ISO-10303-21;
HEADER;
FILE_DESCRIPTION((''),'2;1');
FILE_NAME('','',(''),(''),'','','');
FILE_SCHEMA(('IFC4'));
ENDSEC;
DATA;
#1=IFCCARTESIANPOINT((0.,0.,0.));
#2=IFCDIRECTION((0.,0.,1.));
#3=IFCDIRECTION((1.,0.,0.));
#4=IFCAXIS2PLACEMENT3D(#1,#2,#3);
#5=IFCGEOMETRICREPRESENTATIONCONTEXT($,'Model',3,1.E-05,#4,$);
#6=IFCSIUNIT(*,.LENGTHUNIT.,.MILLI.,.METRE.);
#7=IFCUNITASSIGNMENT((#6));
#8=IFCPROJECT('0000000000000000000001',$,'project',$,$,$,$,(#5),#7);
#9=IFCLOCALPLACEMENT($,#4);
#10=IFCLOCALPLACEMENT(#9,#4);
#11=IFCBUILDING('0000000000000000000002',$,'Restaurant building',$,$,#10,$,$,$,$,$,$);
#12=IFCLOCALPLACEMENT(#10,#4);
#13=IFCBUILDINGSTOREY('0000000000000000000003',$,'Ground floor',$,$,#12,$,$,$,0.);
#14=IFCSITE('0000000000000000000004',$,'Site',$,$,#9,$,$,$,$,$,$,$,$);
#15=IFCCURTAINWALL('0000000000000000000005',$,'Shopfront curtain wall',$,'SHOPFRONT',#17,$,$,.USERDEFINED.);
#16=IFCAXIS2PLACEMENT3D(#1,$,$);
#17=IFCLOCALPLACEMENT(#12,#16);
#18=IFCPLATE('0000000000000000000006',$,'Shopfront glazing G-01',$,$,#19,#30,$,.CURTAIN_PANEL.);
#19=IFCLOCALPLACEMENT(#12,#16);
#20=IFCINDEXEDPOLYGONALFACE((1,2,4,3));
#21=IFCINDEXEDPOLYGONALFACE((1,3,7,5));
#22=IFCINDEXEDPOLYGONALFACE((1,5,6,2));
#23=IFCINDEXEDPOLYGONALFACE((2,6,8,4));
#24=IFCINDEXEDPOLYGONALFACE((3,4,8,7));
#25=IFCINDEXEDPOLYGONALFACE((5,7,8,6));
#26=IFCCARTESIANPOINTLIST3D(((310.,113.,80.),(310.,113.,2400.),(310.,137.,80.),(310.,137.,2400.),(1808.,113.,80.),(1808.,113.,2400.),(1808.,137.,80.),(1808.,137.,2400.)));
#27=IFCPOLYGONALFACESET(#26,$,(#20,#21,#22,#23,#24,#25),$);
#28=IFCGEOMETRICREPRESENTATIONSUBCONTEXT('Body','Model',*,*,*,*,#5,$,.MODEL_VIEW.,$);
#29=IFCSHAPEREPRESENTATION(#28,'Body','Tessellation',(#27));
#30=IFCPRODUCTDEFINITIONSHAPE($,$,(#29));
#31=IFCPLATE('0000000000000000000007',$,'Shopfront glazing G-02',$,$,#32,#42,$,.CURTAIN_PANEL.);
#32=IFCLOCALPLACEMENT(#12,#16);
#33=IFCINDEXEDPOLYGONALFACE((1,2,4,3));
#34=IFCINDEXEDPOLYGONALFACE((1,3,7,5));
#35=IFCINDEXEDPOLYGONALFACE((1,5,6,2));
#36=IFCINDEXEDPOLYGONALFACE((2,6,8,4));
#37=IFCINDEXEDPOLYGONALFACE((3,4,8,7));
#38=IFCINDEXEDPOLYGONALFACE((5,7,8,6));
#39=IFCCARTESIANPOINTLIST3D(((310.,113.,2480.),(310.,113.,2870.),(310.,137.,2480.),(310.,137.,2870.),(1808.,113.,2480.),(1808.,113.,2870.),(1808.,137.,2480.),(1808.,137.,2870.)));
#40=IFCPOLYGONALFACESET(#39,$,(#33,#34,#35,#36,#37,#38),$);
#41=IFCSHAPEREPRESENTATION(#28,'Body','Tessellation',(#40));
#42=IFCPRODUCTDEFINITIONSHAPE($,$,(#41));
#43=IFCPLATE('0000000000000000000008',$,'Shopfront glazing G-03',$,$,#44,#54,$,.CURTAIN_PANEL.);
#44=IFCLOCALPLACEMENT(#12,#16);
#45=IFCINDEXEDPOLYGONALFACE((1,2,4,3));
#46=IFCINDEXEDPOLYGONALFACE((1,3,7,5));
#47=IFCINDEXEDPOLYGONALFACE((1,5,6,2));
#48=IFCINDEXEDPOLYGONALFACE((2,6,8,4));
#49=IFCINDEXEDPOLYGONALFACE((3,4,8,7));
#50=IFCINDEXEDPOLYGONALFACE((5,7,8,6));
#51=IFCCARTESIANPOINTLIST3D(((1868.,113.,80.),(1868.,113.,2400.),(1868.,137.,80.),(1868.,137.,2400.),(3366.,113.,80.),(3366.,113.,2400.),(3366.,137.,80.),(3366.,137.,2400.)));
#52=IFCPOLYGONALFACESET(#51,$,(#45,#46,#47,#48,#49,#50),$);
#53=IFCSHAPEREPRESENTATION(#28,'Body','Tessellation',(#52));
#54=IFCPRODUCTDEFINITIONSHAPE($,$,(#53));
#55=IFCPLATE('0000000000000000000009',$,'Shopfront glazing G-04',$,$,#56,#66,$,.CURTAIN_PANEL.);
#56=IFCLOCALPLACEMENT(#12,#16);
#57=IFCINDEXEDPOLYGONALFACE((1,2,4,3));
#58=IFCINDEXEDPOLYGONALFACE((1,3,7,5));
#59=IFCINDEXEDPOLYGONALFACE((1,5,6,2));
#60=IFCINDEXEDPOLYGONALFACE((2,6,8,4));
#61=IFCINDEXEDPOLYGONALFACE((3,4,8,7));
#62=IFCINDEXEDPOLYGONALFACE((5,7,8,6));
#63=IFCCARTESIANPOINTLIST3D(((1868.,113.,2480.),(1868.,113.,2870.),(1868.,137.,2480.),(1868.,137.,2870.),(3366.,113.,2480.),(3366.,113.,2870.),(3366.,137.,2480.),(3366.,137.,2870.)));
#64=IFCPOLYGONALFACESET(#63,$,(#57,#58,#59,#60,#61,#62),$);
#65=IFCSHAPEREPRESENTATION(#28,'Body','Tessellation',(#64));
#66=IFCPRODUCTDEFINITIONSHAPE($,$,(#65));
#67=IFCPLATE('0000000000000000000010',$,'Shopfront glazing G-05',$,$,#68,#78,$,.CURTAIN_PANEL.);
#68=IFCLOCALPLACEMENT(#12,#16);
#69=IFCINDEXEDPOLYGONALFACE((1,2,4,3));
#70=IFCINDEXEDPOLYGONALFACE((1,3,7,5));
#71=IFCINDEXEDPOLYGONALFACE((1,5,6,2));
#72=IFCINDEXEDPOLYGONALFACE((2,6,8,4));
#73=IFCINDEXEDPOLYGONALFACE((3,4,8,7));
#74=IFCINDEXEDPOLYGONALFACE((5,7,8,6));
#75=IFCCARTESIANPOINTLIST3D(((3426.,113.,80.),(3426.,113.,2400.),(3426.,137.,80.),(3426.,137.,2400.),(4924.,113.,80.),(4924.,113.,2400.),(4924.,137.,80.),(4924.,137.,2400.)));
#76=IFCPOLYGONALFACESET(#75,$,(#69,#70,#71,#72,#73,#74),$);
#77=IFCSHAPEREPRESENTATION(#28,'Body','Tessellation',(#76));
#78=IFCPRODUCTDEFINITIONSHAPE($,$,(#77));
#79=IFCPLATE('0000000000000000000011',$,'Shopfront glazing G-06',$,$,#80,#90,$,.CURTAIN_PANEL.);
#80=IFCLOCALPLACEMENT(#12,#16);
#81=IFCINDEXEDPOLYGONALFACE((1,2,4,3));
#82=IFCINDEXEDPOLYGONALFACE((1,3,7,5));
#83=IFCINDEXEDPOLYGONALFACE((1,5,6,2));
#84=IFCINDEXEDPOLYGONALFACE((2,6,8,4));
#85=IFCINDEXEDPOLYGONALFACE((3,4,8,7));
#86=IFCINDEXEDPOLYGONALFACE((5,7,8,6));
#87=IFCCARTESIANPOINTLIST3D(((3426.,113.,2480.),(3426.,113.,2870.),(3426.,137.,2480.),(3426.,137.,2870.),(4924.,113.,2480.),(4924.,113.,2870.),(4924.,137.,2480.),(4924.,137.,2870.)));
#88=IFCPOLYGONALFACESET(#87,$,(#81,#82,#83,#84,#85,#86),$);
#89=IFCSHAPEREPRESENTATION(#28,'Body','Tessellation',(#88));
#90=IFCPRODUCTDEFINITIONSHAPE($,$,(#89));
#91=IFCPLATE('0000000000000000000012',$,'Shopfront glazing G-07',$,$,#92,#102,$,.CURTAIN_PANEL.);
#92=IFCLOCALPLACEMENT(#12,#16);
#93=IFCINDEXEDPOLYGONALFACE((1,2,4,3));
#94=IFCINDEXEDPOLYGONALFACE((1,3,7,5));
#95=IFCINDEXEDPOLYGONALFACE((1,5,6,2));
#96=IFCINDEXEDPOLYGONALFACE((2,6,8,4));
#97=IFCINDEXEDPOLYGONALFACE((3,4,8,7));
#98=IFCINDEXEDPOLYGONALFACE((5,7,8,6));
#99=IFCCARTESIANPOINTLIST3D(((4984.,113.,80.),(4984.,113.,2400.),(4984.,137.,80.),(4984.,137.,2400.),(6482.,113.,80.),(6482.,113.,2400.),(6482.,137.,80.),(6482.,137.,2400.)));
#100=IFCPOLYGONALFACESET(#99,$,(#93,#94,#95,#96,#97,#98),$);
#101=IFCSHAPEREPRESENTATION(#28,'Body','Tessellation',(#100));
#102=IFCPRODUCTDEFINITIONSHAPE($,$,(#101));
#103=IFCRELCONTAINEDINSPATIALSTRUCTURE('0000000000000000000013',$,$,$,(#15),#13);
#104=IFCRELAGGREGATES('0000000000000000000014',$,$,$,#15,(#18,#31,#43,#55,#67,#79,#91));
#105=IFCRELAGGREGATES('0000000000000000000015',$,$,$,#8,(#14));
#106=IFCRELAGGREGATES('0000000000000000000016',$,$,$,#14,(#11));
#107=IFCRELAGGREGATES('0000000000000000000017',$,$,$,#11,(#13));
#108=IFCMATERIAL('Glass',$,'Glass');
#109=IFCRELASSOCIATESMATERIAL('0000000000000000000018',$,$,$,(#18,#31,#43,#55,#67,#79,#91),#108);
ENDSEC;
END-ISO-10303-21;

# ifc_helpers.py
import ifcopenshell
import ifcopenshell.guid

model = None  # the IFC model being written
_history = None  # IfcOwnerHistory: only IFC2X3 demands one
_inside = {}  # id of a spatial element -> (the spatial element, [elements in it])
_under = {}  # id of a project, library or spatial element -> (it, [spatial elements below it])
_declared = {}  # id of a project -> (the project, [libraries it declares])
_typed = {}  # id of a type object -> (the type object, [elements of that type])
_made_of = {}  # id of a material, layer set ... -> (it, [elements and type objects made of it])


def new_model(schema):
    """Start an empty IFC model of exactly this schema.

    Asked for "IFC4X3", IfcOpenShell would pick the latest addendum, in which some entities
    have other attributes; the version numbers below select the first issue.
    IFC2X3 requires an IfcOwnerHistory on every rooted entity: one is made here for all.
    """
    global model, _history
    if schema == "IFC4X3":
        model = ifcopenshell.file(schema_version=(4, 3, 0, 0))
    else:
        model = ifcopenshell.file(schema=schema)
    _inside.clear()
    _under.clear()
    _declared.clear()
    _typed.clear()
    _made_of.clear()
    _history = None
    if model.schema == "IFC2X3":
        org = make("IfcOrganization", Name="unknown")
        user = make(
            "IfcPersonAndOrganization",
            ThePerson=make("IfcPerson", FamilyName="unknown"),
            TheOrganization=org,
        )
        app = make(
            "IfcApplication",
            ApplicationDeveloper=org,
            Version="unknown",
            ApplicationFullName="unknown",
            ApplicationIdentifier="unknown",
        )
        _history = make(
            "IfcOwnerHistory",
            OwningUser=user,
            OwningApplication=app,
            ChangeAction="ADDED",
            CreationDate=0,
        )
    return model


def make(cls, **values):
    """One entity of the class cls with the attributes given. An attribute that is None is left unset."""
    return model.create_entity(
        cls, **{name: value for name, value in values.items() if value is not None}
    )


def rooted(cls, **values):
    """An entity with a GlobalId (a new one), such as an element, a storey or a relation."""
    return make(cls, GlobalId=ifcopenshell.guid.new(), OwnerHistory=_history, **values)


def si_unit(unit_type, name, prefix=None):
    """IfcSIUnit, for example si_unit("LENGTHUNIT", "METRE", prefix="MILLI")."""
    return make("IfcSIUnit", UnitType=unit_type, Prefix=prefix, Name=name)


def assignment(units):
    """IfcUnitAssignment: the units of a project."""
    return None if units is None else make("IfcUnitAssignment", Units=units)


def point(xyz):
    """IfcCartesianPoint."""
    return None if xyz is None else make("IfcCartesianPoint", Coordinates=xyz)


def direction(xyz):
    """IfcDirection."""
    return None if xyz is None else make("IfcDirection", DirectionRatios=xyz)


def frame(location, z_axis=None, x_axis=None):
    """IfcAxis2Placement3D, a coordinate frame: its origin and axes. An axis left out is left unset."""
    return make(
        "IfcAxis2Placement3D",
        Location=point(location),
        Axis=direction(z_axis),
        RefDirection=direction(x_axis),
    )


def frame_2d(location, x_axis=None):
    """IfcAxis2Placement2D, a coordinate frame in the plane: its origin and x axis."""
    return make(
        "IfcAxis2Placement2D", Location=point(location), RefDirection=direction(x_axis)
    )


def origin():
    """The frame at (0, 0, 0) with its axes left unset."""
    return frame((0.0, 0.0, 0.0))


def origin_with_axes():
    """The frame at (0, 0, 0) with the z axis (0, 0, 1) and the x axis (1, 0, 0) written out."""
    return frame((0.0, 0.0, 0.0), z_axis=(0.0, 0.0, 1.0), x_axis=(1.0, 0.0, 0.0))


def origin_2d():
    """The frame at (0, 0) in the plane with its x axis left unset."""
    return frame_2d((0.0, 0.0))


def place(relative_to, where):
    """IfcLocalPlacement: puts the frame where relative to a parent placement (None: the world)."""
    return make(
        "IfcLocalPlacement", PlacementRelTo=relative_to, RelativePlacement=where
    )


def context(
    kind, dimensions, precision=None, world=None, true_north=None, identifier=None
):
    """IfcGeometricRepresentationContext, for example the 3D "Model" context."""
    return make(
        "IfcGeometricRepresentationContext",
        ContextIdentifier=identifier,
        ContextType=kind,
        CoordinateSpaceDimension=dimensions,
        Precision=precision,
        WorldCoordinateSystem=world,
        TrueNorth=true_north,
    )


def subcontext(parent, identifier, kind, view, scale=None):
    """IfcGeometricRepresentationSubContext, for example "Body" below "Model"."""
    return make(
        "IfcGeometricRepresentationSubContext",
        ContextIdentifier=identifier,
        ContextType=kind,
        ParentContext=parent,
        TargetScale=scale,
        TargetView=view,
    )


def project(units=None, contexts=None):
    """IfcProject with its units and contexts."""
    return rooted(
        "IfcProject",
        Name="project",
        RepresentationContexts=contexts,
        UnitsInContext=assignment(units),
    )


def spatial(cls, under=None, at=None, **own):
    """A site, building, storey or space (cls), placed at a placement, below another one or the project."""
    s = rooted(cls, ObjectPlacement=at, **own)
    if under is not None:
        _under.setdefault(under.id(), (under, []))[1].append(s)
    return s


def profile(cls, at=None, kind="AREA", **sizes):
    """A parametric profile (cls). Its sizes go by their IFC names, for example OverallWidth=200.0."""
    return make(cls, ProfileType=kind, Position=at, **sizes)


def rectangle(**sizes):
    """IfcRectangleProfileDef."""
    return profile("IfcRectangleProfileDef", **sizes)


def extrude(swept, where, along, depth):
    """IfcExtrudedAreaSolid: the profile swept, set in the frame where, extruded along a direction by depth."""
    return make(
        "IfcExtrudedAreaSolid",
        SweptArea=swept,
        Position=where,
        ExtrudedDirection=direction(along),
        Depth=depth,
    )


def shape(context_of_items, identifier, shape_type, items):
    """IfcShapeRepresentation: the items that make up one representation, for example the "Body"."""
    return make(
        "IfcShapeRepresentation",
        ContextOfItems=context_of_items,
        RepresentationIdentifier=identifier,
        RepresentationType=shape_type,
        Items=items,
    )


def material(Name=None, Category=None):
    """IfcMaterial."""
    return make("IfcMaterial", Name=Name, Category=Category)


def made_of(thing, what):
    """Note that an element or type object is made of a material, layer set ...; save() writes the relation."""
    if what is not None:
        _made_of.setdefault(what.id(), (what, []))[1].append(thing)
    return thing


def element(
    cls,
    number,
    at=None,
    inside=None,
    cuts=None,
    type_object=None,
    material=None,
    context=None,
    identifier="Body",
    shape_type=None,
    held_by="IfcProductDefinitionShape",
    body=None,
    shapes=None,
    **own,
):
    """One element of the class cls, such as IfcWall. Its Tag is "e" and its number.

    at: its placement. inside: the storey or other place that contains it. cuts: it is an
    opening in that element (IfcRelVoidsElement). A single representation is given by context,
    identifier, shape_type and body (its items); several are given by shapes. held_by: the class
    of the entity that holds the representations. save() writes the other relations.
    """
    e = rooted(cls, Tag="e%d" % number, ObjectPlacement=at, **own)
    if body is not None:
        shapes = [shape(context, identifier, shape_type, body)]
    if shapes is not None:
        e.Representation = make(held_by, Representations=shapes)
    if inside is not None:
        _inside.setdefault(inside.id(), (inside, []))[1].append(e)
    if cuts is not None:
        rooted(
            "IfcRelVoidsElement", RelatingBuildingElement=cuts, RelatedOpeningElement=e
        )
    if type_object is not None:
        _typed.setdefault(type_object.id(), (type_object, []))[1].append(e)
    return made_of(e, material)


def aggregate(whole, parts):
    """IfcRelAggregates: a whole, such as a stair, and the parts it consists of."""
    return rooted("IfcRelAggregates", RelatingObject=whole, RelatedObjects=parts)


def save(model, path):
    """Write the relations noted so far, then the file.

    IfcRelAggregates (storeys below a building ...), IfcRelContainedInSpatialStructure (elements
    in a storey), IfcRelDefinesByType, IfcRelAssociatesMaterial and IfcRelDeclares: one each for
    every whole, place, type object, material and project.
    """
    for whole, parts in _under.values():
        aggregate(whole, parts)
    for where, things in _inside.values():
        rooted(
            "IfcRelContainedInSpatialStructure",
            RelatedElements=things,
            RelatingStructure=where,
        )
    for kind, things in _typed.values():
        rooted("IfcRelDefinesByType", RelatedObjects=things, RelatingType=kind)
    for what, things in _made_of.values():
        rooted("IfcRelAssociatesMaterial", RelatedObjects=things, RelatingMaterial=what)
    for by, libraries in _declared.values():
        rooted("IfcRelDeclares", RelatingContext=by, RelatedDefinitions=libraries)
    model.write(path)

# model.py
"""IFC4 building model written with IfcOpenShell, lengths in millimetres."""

from ifc_helpers import new_model, si_unit, frame, origin, origin_with_axes, origin_2d, place, context, subcontext, project, spatial, rectangle, extrude, material, element, aggregate, save


model = new_model("IFC4")

# Units and contexts
model_context = context("Model", 3, precision=1e-05, world=origin_with_axes())
body_context = subcontext(model_context, "Body", "Model", "MODEL_VIEW")
ifc_project = project(units=[si_unit("LENGTHUNIT", "METRE", prefix="MILLI")], contexts=[model_context])

# Site, building, storey
site_placement = place(None, origin_with_axes())
site = spatial("IfcSite", under=ifc_project, at=site_placement, Name="Site")
building_placement = place(site_placement, origin_with_axes())
building = spatial("IfcBuilding", under=site, at=building_placement, Name="Restaurant building")
storey_placement = place(building_placement, origin_with_axes())
storey = spatial("IfcBuildingStorey", under=building, at=storey_placement, Name="Ground floor", Elevation=0.0)

# Curtain wall, plates
curtain_wall_placement = place(storey_placement, origin())
curtain_wall = element("IfcCurtainWall", 1, at=curtain_wall_placement, inside=storey, Name="Shopfront curtain wall", ObjectType="SHOPFRONT", PredefinedType="USERDEFINED")
ifc_material_1 = material(Name="Glass", Category="Glass")
plate_1_placement = place(curtain_wall_placement, origin_with_axes())
plate_1 = element("IfcPlate", 2, at=plate_1_placement, material=ifc_material_1, Name="Shopfront glazing G-01", PredefinedType="CURTAIN_PANEL", context=body_context, shape_type="SweptSolid", body=[
    extrude(rectangle(XDim=1498.0, YDim=24.0, at=origin_2d()), frame((1059.0, 125.0, 80.0)), (0.0, 0.0, 1.0), 2320.0),
])
plate_2_placement = place(curtain_wall_placement, origin_with_axes())
plate_2 = element("IfcPlate", 3, at=plate_2_placement, material=ifc_material_1, Name="Shopfront glazing G-02", PredefinedType="CURTAIN_PANEL", context=body_context, shape_type="SweptSolid", body=[
    extrude(rectangle(XDim=1498.0, YDim=24.0, at=origin_2d()), frame((1059.0, 125.0, 2480.0)), (0.0, 0.0, 1.0), 390.0),
])
plate_3_placement = place(curtain_wall_placement, origin_with_axes())
plate_3 = element("IfcPlate", 4, at=plate_3_placement, material=ifc_material_1, Name="Shopfront glazing G-03", PredefinedType="CURTAIN_PANEL", context=body_context, shape_type="SweptSolid", body=[
    extrude(rectangle(XDim=1498.0, YDim=24.0, at=origin_2d()), frame((2617.0, 125.0, 80.0)), (0.0, 0.0, 1.0), 2320.0),
])
plate_4_placement = place(curtain_wall_placement, origin_with_axes())
plate_4 = element("IfcPlate", 5, at=plate_4_placement, material=ifc_material_1, Name="Shopfront glazing G-04", PredefinedType="CURTAIN_PANEL", context=body_context, shape_type="SweptSolid", body=[
    extrude(rectangle(XDim=1498.0, YDim=24.0, at=origin_2d()), frame((2617.0, 125.0, 2480.0)), (0.0, 0.0, 1.0), 390.0),
])
plate_5_placement = place(curtain_wall_placement, origin_with_axes())
plate_5 = element("IfcPlate", 6, at=plate_5_placement, material=ifc_material_1, Name="Shopfront glazing G-05", PredefinedType="CURTAIN_PANEL", context=body_context, shape_type="SweptSolid", body=[
    extrude(rectangle(XDim=1498.0, YDim=24.0, at=origin_2d()), frame((4175.0, 125.0, 80.0)), (0.0, 0.0, 1.0), 2320.0),
])
plate_6_placement = place(curtain_wall_placement, origin_with_axes())
plate_6 = element("IfcPlate", 7, at=plate_6_placement, material=ifc_material_1, Name="Shopfront glazing G-06", PredefinedType="CURTAIN_PANEL", context=body_context, shape_type="SweptSolid", body=[
    extrude(rectangle(XDim=1498.0, YDim=24.0, at=origin_2d()), frame((4175.0, 125.0, 2480.0)), (0.0, 0.0, 1.0), 390.0),
])
plate_7_placement = place(curtain_wall_placement, origin_with_axes())
plate_7 = element("IfcPlate", 8, at=plate_7_placement, material=ifc_material_1, Name="Shopfront glazing G-07", PredefinedType="CURTAIN_PANEL", context=body_context, shape_type="SweptSolid", body=[
    extrude(rectangle(XDim=1498.0, YDim=24.0, at=origin_2d()), frame((5733.0, 125.0, 80.0)), (0.0, 0.0, 1.0), 2320.0),
])
aggregate(curtain_wall, [plate_1, plate_2, plate_3, plate_4, plate_5, plate_6, plate_7])

save(model, "model.ifc")
